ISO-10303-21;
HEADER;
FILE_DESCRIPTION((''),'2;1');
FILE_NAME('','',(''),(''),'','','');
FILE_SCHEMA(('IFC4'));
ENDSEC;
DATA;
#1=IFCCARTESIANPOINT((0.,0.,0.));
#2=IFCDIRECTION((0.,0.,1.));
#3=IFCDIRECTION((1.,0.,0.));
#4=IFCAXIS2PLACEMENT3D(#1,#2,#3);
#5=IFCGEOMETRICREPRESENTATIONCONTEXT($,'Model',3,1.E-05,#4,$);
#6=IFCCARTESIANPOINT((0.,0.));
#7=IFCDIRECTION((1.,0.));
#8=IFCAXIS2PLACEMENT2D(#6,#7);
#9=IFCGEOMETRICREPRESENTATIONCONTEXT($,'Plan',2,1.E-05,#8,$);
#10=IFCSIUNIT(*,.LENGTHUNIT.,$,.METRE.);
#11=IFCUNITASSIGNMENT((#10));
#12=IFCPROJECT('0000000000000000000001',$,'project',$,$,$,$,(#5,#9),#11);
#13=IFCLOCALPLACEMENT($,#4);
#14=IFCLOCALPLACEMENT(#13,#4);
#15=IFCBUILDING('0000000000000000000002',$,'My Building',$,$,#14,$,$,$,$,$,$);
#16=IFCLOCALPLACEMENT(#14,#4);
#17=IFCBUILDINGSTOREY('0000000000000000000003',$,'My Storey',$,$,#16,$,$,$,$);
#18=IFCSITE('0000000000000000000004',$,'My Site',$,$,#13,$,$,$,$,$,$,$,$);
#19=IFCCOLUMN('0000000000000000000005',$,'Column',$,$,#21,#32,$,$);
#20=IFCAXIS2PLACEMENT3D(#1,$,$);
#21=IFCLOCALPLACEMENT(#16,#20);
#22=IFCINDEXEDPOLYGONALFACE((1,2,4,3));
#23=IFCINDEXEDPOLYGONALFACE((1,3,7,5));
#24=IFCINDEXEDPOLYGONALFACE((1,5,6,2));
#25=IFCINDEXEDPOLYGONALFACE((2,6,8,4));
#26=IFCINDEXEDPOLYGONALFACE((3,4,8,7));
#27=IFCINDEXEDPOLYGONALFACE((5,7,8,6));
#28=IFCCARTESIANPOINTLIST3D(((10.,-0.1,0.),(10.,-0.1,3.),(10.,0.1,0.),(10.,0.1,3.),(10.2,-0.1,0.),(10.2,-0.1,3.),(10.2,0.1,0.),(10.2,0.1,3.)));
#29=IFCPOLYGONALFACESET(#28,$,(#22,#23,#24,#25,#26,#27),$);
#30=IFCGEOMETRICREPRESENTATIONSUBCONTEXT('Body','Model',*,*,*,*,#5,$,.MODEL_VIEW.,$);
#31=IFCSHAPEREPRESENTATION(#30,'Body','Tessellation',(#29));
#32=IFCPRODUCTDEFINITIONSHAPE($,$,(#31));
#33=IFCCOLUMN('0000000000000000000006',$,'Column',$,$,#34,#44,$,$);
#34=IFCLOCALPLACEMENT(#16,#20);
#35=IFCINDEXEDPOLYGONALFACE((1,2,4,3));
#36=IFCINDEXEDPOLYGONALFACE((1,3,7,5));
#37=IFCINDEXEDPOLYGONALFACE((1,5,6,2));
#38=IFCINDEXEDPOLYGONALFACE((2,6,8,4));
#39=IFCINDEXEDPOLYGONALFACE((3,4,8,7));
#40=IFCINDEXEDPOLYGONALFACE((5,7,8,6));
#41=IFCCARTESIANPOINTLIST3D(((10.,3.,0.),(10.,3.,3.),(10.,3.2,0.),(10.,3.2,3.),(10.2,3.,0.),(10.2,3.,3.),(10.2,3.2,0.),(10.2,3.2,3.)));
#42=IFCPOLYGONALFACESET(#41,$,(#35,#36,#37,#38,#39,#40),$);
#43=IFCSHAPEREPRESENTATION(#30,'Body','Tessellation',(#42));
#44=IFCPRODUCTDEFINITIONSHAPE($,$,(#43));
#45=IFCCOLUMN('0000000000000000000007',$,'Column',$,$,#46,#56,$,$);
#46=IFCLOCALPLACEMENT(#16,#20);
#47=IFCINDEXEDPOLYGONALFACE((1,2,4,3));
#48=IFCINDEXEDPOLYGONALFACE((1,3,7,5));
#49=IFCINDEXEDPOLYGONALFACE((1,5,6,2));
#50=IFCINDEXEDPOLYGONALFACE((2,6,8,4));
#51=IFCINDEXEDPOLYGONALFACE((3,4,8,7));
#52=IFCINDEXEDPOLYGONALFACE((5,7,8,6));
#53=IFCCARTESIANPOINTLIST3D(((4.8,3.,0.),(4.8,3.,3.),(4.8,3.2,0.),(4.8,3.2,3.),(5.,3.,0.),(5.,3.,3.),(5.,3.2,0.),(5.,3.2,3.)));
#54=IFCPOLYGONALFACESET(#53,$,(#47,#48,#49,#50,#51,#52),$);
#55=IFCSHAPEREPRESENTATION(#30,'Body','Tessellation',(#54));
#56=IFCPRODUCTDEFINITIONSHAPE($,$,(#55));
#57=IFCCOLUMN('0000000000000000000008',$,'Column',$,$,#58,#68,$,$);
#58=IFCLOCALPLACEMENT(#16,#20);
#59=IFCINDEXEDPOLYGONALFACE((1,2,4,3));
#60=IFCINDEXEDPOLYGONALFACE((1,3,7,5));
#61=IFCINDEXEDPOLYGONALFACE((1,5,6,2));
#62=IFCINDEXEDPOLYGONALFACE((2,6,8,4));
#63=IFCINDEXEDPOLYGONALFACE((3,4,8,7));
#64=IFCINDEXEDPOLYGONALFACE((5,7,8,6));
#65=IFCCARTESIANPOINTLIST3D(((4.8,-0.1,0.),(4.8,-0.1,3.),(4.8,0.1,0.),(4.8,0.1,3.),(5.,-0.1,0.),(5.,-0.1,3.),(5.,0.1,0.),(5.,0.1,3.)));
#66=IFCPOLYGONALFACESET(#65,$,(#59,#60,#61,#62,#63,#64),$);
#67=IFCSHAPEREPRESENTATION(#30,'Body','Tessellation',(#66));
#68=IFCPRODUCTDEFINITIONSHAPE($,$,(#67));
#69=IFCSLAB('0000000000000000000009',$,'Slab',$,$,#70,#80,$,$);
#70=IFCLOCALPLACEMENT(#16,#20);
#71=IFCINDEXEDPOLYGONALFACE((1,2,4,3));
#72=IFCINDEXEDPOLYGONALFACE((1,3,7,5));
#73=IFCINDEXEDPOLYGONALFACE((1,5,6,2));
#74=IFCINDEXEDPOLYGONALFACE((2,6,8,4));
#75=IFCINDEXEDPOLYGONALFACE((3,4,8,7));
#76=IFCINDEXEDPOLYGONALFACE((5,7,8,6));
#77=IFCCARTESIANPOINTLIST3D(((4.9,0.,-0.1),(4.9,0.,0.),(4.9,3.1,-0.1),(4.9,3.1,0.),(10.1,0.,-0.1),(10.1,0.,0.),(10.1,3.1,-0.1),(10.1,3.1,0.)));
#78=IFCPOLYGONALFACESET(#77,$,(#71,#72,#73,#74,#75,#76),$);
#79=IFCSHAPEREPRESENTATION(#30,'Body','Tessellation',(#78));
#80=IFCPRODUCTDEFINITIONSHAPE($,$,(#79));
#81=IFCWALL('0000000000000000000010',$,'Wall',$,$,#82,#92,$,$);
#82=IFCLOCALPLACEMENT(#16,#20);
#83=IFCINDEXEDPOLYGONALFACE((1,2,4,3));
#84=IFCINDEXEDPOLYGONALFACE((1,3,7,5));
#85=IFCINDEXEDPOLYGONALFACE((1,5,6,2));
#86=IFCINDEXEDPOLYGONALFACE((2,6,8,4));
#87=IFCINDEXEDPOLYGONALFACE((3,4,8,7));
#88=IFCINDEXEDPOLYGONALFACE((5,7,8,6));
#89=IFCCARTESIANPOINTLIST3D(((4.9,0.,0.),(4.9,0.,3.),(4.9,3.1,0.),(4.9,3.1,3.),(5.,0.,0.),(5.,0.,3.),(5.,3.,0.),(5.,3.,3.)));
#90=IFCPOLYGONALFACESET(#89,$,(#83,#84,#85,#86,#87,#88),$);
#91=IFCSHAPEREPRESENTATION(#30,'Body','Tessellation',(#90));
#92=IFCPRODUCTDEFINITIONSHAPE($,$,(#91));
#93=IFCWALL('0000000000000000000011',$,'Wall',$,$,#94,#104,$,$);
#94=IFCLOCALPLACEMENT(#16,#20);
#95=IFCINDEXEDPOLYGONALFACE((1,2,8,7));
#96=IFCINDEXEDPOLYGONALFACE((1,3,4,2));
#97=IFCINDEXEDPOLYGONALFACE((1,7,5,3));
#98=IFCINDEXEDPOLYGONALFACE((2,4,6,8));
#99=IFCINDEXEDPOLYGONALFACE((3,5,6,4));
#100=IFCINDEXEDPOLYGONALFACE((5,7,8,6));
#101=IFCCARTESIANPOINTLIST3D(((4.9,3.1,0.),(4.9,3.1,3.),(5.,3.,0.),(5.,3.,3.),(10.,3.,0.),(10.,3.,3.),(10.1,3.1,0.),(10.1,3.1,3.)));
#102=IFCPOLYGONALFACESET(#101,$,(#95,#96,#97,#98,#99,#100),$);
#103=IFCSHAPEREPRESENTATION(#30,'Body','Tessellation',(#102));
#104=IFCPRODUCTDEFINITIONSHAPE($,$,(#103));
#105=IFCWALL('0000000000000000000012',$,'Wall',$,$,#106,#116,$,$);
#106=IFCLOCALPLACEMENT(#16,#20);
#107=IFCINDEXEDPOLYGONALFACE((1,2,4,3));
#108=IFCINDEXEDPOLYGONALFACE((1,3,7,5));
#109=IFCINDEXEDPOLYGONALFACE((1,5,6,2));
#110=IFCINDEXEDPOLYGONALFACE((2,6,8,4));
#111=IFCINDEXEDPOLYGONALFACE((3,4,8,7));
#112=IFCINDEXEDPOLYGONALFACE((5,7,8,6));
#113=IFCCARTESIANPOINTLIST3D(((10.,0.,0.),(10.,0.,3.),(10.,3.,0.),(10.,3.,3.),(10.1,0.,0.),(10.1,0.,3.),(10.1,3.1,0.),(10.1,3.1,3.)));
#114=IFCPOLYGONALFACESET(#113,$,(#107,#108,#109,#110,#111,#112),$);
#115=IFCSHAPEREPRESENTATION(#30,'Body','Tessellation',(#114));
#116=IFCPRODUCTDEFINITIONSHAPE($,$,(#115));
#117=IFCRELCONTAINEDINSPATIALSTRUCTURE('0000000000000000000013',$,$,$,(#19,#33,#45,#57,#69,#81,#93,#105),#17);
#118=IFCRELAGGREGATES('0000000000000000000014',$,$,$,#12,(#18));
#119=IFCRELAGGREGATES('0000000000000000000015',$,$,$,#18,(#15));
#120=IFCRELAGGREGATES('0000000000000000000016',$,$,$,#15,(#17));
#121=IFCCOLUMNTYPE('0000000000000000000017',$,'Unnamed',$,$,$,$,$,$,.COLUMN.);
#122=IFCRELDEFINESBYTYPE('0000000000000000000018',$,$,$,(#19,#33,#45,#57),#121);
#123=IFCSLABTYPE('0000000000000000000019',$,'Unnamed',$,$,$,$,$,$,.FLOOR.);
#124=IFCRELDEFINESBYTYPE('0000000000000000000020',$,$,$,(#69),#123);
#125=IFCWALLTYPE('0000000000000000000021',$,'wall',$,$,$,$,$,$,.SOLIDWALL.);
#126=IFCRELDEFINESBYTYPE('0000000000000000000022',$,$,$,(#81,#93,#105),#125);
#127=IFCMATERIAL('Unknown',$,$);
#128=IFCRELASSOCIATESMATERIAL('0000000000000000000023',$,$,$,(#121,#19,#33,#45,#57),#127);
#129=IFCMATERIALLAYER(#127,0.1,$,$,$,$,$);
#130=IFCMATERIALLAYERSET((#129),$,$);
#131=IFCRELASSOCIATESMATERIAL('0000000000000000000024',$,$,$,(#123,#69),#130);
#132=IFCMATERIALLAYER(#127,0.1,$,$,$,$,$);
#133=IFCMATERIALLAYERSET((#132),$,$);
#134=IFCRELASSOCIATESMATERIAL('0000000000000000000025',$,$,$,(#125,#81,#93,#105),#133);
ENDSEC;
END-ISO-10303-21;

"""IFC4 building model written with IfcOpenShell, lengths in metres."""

from ifc_helpers import new_model, si_unit, frame, origin_with_axes, origin_2d_with_axis, place, context, subcontext, project, spatial, line, indexed_curve, rectangle, outline, extrude, material, layer, layer_set, layer_usage, material_profile, profile_set, profile_usage, type_object, element, save


model = new_model("IFC4")

# Units and contexts
model_context = context("Model", 3, precision=1e-05, world=origin_with_axes())
plan_context = context("Plan", 2, precision=1e-05, world=origin_2d_with_axis())
body_context_1 = subcontext(model_context, "Body", "Model", "MODEL_VIEW")
ifc_project = project(units=[si_unit("LENGTHUNIT", "METRE")], contexts=[model_context, plan_context])

# Site, building, storey
site_placement = place(None, origin_with_axes())
site = spatial("IfcSite", under=ifc_project, at=site_placement, Name="My Site")
building_placement = place(site_placement, origin_with_axes())
building = spatial("IfcBuilding", under=site, at=building_placement, Name="My Building")
storey_placement = place(building_placement, origin_with_axes())
storey = spatial("IfcBuildingStorey", under=building, at=storey_placement, Name="My Storey")

# Columns
ifc_material = material(Name="Unknown")
ifc_material_profile = material_profile(ifc_material, rectangle(XDim=0.2, YDim=0.2))
ifc_profile_set = profile_set([ifc_material_profile])
ifc_profile_usage_1 = profile_usage(ifc_profile_set, cardinal=5)
column_type = type_object("IfcColumnType", Name="Unnamed", PredefinedType="COLUMN", material=ifc_profile_set)
column_1_placement = place(storey_placement, frame((10.1, 0.0, 0.0), z_axis=(0.0, 0.0, 1.0), x_axis=(1.0, 0.0, 0.0)))
element("IfcColumn", 1, at=column_1_placement, inside=storey, type_object=column_type, material=ifc_profile_usage_1, Name="Column", context=body_context_1, shape_type="SweptSolid", body=[
    extrude(rectangle(XDim=0.2, YDim=0.2), origin_with_axes(), (0.0, 0.0, 1.0), 3.0),
])
ifc_profile_usage_2 = profile_usage(ifc_profile_set, cardinal=5)
column_2_placement = place(storey_placement, frame((10.1, 3.1, 0.0), z_axis=(0.0, 0.0, 1.0), x_axis=(1.0, 0.0, 0.0)))
element("IfcColumn", 2, at=column_2_placement, inside=storey, type_object=column_type, material=ifc_profile_usage_2, Name="Column", context=body_context_1, shape_type="SweptSolid", body=[
    extrude(rectangle(XDim=0.2, YDim=0.2), origin_with_axes(), (0.0, 0.0, 1.0), 3.0),
])
ifc_profile_usage_3 = profile_usage(ifc_profile_set, cardinal=5)
column_3_placement = place(storey_placement, frame((4.9, 3.1, 0.0), z_axis=(0.0, 0.0, 1.0), x_axis=(1.0, 0.0, 0.0)))
element("IfcColumn", 3, at=column_3_placement, inside=storey, type_object=column_type, material=ifc_profile_usage_3, Name="Column", context=body_context_1, shape_type="SweptSolid", body=[
    extrude(rectangle(XDim=0.2, YDim=0.2), origin_with_axes(), (0.0, 0.0, 1.0), 3.0),
])
ifc_profile_usage_4 = profile_usage(ifc_profile_set, cardinal=5)
column_4_placement = place(storey_placement, frame((4.9, 0.0, 0.0), z_axis=(0.0, 0.0, 1.0), x_axis=(1.0, 0.0, 0.0)))
element("IfcColumn", 4, at=column_4_placement, inside=storey, type_object=column_type, material=ifc_profile_usage_4, Name="Column", context=body_context_1, shape_type="SweptSolid", body=[
    extrude(rectangle(XDim=0.2, YDim=0.2), origin_with_axes(), (0.0, 0.0, 1.0), 3.0),
])

# Slab
ifc_layer_1 = layer(ifc_material, 0.1)
ifc_layer_set_1 = layer_set([ifc_layer_1])
ifc_layer_usage_1 = layer_usage(ifc_layer_set_1, "AXIS3", "POSITIVE", -0.1)
slab_type = type_object("IfcSlabType", Name="Unnamed", PredefinedType="FLOOR", material=ifc_layer_set_1)
slab_placement = place(storey_placement, frame((10.1, 3.1, 0.0), z_axis=(0.0, 0.0, 1.0), x_axis=(1.0, 0.0, 0.0)))
element("IfcSlab", 5, at=slab_placement, inside=storey, type_object=slab_type, material=ifc_layer_usage_1, Name="Slab", context=body_context_1, shape_type="SweptSolid", body=[
    extrude(outline(indexed_curve([(0.0, 0.0), (-5.2, 0.0), (-5.2, -3.1), (0.0, -3.1), (0.0, 0.0)])), frame((0.0, 0.0, -0.1), z_axis=(0.0, 0.0, 1.0), x_axis=(1.0, 0.0, 0.0)), (0.0, 0.0, 1.0), 0.1),
])

# Walls
ifc_layer_2 = layer(ifc_material, 0.1)
ifc_layer_set_2 = layer_set([ifc_layer_2])
ifc_layer_usage_2 = layer_usage(ifc_layer_set_2, "AXIS2", "POSITIVE", 0.0)
wall_type = type_object("IfcWallType", Name="wall", PredefinedType="SOLIDWALL", material=ifc_layer_set_2)
wall_1_placement = place(storey_placement, frame((5.0, 0.0, 0.0), z_axis=(0.0, 0.0, 1.0), x_axis=(0.0, 1.0, 0.0)))
element("IfcWall", 6, at=wall_1_placement, inside=storey, type_object=wall_type, material=ifc_layer_usage_2, Name="Wall", context=body_context_1, shape_type="SweptSolid", body=[
    extrude(outline(indexed_curve([(0.0, 0.0), (0.0, 0.1), (3.1, 0.1), (3.0, 0.0)], segments=[line(1, 2, 3, 4, 1)])), origin_with_axes(), (0.0, 0.0, 1.0), 3.0),
])
ifc_layer_usage_3 = layer_usage(ifc_layer_set_2, "AXIS2", "POSITIVE", 0.0)
wall_2_placement = place(storey_placement, frame((5.0, 3.0, 0.0), z_axis=(0.0, 0.0, 1.0), x_axis=(1.0, 0.0, 0.0)))
element("IfcWall", 7, at=wall_2_placement, inside=storey, type_object=wall_type, material=ifc_layer_usage_3, Name="Wall", context=body_context_1, shape_type="SweptSolid", body=[
    extrude(outline(indexed_curve([(0.0, 0.0), (-0.1, 0.1), (5.1, 0.1), (5.0, 0.0)], segments=[line(1, 2, 3, 4, 1)])), origin_with_axes(), (0.0, 0.0, 1.0), 3.0),
])
ifc_layer_usage_4 = layer_usage(ifc_layer_set_2, "AXIS2", "POSITIVE", 0.0)
wall_3_placement = place(storey_placement, frame((10.0, 3.0, 0.0), z_axis=(0.0, 0.0, 1.0), x_axis=(0.0, -1.0, 0.0)))
element("IfcWall", 8, at=wall_3_placement, inside=storey, type_object=wall_type, material=ifc_layer_usage_4, Name="Wall", context=body_context_1, shape_type="SweptSolid", body=[
    extrude(outline(indexed_curve([(0.0, 0.0), (-0.1, 0.1), (3.0, 0.1), (3.0, 0.0)], segments=[line(1, 2, 3, 4, 1)])), origin_with_axes(), (0.0, 0.0, 1.0), 3.0),
])

save(model, "model.ifc")
